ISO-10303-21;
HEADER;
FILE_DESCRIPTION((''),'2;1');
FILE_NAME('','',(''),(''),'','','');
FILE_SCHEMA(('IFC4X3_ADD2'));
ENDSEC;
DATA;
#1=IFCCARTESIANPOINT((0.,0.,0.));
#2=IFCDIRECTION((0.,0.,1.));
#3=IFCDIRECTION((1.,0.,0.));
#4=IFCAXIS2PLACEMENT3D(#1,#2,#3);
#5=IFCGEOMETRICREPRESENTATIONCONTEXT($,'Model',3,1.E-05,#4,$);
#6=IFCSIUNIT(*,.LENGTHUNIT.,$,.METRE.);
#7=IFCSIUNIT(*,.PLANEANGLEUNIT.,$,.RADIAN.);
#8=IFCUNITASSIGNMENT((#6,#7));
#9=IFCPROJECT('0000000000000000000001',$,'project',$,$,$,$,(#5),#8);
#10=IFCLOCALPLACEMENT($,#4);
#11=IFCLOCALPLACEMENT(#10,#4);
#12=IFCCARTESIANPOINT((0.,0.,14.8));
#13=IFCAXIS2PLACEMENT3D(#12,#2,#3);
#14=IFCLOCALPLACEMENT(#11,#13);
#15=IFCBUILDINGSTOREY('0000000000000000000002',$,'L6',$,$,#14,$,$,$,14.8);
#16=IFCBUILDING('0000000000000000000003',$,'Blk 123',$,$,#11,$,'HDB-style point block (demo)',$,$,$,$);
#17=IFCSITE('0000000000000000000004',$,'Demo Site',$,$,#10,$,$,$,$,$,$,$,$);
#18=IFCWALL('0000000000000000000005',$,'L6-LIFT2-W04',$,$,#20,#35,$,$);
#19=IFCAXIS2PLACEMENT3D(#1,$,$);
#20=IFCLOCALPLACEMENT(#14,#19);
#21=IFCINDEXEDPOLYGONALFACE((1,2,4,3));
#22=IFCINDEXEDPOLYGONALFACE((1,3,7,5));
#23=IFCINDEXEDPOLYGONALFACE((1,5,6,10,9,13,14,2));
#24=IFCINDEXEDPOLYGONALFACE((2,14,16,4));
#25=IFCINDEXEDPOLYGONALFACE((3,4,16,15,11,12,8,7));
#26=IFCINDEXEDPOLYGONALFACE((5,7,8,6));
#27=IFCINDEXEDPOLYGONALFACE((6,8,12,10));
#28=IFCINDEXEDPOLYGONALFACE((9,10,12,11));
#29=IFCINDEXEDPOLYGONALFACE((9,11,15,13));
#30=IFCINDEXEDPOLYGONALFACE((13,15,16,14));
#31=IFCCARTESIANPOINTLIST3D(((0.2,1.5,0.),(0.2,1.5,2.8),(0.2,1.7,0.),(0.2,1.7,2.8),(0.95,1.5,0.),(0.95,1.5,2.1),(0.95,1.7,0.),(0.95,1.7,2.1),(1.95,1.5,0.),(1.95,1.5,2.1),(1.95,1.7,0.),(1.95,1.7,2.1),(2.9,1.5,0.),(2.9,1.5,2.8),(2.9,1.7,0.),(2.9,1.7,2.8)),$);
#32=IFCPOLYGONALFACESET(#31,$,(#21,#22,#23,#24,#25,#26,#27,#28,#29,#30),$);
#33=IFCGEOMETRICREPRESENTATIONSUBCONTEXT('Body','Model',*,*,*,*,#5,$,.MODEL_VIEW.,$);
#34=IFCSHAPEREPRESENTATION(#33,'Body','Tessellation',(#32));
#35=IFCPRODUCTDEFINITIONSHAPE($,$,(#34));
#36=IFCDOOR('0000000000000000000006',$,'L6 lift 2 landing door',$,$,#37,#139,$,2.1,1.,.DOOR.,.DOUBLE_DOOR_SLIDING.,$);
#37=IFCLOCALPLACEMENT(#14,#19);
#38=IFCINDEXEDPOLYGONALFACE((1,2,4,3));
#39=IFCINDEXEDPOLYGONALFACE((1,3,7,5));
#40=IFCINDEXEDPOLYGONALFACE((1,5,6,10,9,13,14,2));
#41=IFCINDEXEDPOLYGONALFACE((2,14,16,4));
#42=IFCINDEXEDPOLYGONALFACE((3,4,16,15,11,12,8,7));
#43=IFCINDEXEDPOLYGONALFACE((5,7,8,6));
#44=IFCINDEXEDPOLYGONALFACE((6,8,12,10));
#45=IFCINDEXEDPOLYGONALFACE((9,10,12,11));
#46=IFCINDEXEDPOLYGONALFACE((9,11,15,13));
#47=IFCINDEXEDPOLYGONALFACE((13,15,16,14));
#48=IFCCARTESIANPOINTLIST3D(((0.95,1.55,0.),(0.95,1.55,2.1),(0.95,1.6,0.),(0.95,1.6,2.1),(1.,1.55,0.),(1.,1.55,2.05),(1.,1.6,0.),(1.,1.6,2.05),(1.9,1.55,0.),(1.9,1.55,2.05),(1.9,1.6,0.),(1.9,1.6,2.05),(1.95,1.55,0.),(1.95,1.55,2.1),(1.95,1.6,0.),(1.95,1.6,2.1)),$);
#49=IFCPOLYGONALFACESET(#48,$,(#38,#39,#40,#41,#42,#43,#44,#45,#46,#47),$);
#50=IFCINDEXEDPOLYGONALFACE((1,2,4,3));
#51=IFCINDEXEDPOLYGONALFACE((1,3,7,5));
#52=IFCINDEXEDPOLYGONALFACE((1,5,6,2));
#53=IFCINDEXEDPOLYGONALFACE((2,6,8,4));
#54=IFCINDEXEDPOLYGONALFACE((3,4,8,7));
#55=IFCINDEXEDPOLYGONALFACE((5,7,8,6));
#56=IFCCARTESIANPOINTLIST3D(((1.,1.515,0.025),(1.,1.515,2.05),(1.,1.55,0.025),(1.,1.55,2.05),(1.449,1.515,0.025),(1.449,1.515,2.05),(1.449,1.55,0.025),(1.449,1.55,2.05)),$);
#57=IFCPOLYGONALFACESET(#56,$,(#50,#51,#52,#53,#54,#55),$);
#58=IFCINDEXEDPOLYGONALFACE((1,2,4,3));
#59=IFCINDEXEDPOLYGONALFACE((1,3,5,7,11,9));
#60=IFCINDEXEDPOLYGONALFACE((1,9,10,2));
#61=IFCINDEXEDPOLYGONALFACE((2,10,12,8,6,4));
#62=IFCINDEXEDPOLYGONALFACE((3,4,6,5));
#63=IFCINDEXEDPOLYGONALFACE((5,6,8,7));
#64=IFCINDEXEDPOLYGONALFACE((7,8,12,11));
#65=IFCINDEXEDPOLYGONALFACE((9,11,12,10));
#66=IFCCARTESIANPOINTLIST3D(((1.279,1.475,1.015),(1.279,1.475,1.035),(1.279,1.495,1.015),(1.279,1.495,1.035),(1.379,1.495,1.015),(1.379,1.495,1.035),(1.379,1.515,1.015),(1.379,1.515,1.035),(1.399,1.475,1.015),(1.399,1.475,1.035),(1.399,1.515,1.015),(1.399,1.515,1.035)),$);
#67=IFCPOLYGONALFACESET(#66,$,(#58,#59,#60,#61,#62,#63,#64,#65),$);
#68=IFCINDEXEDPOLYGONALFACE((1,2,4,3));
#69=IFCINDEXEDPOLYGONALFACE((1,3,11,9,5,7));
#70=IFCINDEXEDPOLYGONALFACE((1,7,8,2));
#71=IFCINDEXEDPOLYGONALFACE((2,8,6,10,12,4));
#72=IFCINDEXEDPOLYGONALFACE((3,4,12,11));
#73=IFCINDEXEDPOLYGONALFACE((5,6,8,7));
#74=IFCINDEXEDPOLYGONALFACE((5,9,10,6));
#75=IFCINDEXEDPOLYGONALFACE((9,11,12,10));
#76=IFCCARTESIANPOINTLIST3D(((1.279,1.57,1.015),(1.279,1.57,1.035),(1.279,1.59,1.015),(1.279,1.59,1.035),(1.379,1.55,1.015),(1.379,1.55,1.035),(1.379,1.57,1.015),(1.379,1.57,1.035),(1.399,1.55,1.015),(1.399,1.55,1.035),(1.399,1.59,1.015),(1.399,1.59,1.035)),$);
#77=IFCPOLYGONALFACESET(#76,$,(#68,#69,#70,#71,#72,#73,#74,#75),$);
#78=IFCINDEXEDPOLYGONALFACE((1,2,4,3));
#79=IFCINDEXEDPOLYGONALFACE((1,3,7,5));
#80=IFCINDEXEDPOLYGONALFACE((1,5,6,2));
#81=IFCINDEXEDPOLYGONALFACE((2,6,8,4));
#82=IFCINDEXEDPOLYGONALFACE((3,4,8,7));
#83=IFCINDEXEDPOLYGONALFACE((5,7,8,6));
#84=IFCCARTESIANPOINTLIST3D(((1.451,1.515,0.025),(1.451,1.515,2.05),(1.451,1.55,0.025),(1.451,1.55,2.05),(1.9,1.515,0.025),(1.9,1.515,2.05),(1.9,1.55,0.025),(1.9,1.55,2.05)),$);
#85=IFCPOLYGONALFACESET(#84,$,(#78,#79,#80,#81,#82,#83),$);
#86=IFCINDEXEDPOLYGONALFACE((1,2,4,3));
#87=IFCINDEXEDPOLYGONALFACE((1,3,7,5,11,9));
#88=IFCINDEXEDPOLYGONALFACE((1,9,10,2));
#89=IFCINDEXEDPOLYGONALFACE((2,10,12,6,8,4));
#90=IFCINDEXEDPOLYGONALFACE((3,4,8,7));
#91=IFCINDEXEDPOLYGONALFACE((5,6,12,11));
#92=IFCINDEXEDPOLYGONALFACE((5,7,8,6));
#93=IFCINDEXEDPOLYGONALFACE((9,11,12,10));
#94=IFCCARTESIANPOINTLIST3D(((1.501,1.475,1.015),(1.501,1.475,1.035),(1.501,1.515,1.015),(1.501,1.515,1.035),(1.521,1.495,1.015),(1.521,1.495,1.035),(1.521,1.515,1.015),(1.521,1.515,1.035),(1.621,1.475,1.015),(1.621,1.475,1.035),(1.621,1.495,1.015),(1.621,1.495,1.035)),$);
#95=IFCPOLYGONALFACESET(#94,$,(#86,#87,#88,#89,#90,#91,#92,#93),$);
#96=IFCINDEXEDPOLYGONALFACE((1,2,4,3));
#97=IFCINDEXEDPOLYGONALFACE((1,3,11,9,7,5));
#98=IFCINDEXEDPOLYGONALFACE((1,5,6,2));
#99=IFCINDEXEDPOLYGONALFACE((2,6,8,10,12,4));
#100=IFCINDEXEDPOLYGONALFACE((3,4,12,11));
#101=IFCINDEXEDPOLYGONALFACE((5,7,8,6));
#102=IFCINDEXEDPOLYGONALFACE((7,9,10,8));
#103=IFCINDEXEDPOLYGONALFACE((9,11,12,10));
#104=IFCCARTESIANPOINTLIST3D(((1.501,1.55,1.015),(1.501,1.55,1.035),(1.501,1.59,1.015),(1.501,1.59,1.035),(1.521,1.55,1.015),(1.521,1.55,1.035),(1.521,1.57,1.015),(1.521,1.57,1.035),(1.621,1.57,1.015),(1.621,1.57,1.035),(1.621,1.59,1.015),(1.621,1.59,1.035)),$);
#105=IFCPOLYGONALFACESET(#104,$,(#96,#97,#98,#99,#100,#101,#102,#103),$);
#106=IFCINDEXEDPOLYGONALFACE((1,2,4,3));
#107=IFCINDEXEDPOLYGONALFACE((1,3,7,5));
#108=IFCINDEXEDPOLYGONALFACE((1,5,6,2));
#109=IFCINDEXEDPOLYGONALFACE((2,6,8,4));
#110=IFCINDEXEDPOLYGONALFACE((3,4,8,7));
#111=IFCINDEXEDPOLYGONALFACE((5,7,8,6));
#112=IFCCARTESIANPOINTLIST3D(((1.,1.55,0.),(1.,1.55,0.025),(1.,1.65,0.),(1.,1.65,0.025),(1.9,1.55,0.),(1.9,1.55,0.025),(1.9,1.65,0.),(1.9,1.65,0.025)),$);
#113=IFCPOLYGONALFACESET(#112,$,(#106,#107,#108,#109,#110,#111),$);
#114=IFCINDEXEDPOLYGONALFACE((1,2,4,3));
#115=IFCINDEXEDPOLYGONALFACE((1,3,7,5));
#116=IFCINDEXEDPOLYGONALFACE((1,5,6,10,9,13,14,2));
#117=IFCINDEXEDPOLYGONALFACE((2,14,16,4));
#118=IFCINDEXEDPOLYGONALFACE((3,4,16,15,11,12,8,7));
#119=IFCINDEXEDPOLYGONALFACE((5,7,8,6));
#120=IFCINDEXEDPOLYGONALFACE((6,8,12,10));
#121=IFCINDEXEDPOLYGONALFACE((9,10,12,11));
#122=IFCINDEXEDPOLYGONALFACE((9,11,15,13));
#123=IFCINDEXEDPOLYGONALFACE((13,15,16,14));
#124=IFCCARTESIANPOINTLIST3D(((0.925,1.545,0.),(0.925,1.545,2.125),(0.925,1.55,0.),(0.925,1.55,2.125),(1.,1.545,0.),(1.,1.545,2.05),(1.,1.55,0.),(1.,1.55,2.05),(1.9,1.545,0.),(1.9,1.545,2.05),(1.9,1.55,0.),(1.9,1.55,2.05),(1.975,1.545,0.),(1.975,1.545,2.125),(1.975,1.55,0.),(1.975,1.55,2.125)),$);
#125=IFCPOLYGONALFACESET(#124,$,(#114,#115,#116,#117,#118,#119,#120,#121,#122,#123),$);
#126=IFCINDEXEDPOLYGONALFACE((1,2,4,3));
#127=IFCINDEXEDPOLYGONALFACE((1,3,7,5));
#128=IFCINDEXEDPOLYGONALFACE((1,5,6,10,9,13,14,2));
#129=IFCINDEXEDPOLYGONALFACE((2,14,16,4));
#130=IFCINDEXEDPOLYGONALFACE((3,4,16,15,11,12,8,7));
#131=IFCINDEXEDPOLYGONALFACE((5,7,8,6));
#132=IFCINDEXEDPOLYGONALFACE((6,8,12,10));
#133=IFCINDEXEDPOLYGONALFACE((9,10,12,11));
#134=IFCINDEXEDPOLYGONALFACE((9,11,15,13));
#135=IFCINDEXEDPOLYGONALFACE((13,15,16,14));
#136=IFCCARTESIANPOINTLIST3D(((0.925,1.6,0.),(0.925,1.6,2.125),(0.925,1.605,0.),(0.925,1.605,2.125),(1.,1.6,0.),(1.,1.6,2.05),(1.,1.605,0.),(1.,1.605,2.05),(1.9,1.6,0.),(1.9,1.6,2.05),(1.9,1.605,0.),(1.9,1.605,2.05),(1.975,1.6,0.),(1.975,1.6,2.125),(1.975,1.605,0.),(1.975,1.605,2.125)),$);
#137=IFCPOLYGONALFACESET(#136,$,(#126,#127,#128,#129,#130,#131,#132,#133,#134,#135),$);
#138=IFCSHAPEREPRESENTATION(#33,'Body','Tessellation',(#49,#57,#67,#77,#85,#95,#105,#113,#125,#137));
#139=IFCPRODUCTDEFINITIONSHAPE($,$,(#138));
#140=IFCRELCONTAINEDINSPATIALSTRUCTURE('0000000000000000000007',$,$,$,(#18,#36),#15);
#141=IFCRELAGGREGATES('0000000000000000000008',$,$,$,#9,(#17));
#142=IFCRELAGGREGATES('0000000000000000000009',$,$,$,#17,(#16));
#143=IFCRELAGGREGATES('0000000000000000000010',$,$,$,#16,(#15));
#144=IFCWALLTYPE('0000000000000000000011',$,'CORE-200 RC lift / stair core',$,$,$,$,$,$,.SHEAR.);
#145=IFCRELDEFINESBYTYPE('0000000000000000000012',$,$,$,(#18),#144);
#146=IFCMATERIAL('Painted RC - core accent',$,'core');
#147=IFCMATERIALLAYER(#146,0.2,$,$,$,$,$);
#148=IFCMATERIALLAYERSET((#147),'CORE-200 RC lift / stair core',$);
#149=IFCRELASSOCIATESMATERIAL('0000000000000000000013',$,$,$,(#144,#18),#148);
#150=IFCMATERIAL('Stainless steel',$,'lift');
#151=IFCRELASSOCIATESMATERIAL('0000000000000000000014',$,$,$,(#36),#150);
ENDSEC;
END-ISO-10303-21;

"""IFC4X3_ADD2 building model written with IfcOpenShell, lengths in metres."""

from ifc_helpers import new_model, si_unit, frame, origin_with_axes, place, context, subcontext, project, spatial, line, indexed_curve, outline, extrude, material, layer, layer_set, layer_usage, type_object, element, fill, save


model = new_model("IFC4X3_ADD2")

# Units and contexts
model_context = context("Model", 3, precision=1e-05, world=origin_with_axes())
body_context = subcontext(model_context, "Body", "Model", "MODEL_VIEW")
ifc_project = project(units=[si_unit("LENGTHUNIT", "METRE"), si_unit("PLANEANGLEUNIT", "RADIAN")], contexts=[model_context])

# Site, building, storey
site_placement = place(None, origin_with_axes())
site = spatial("IfcSite", under=ifc_project, at=site_placement, Name="Demo Site")
building_placement = place(site_placement, origin_with_axes())
building = spatial("IfcBuilding", under=site, at=building_placement, Name="Blk 123", LongName="HDB-style point block (demo)")
storey_placement = place(building_placement, frame((0.0, 0.0, 14.8), z_axis=(0.0, 0.0, 1.0), x_axis=(1.0, 0.0, 0.0)))
storey = spatial("IfcBuildingStorey", under=building, at=storey_placement, Name="L6", Elevation=14.8)

# Shared definitions
ifc_material_1 = material(Name="Painted RC - core accent", Category="core")
ifc_layer_1 = layer(ifc_material_1, 0.2)
ifc_layer_set_1 = layer_set([ifc_layer_1], Name="CORE-200 RC lift / stair core")
ifc_layer_usage_1 = layer_usage(ifc_layer_set_1, "AXIS2", "POSITIVE", 0.0)
wall_type_1 = type_object("IfcWallType", Name="CORE-200 RC lift / stair core", PredefinedType="SHEAR", material=ifc_layer_set_1)

# Wall, opening, door
wall_1_placement = place(storey_placement, frame((0.2, 1.5, 0.0), z_axis=(0.0, 0.0, 1.0), x_axis=(1.0, 0.0, 0.0)))
wall_1 = element("IfcWall", 1, at=wall_1_placement, inside=storey, type_object=wall_type_1, material=ifc_layer_usage_1, Name="L6-LIFT2-W04", context=body_context, shape_type="SweptSolid", body=[
    extrude(outline(indexed_curve([(0.0, 0.0), (0.0, 0.2), (2.7, 0.2), (2.7, 0.0), (0.0, 0.0)], self_intersect=False)), origin_with_axes(), (0.0, 0.0, 1.0), 2.8),
])
opening_1_placement = place(wall_1_placement, frame((0.75, -0.1, 0.0), z_axis=(0.0, 0.0, 1.0), x_axis=(1.0, 0.0, 0.0)))
opening_1 = element("IfcOpeningElement", 2, at=opening_1_placement, cuts=wall_1, context=body_context, shape_type="SweptSolid", body=[
    extrude(outline(indexed_curve([(0.0, 0.0), (0.0, 0.4), (1.0, 0.4), (1.0, 0.0), (0.0, 0.0)], self_intersect=False)), origin_with_axes(), (0.0, 0.0, 1.0), 2.1),
])
ifc_material_2 = material(Name="Stainless steel", Category="lift")
door_1_placement = place(opening_1_placement, frame((0.0, 0.15, 0.0), z_axis=(0.0, 0.0, 1.0), x_axis=(1.0, 0.0, 0.0)))
door_1 = element("IfcDoor", 3, at=door_1_placement, inside=storey, material=ifc_material_2, Name="L6 lift 2 landing door", OperationType="DOUBLE_DOOR_SLIDING", OverallHeight=2.1, OverallWidth=1.0, PredefinedType="DOOR", context=body_context, shape_type="SweptSolid", body=[
    extrude(outline(indexed_curve([(0.0, 0.0), (0.0, 2.1), (1.0, 2.1), (1.0, 0.0), (0.95, 0.0), (0.95, 2.05), (0.05, 2.05), (0.05, 0.0)], segments=[line(1, 2, 3, 4, 5, 6, 7, 8, 1)])), frame((0.0, 0.0, 0.0), z_axis=(0.0, -1.0, 0.0), x_axis=(1.0, 0.0, 0.0)), (0.0, 0.0, -1.0), 0.05),
    extrude(outline(indexed_curve([(0.0, 0.0), (0.449, 0.0), (0.449, 0.035), (0.0, 0.035)], segments=[line(1, 2, 3, 4, 1)])), frame((0.05, -0.035, 0.025), z_axis=(0.0, 0.0, 1.0), x_axis=(1.0, 0.0, 0.0)), (0.0, 0.0, 1.0), 2.025),
    extrude(outline(indexed_curve([(0.0, 0.0), (0.0, -0.04), (-0.12, -0.04), (-0.12, -0.02), (-0.02, -0.02), (-0.02, 0.0)], segments=[line(1, 2, 3, 4, 5, 6, 1)])), frame((0.449, -0.035, 1.015), z_axis=(0.0, 0.0, 1.0), x_axis=(1.0, 0.0, 0.0)), (0.0, 0.0, 1.0), 0.02),
    extrude(outline(indexed_curve([(0.0, 0.0), (0.0, 0.04), (-0.12, 0.04), (-0.12, 0.02), (-0.02, 0.02), (-0.02, 0.0)], segments=[line(1, 2, 3, 4, 5, 6, 1)])), frame((0.449, 0.0, 1.015), z_axis=(0.0, 0.0, 1.0), x_axis=(1.0, 0.0, 0.0)), (0.0, 0.0, 1.0), 0.02),
    extrude(outline(indexed_curve([(0.0, 0.0), (-0.449, 0.0), (-0.449, 0.035), (0.0, 0.035)], segments=[line(1, 2, 3, 4, 1)])), frame((0.95, -0.035, 0.025), z_axis=(0.0, 0.0, 1.0), x_axis=(1.0, 0.0, 0.0)), (0.0, 0.0, 1.0), 2.025),
    extrude(outline(indexed_curve([(0.0, 0.0), (0.0, -0.04), (0.12, -0.04), (0.12, -0.02), (0.02, -0.02), (0.02, 0.0)], segments=[line(1, 2, 3, 4, 5, 6, 1)])), frame((0.551, -0.035, 1.015), z_axis=(0.0, 0.0, 1.0), x_axis=(1.0, 0.0, 0.0)), (0.0, 0.0, 1.0), 0.02),
    extrude(outline(indexed_curve([(0.0, 0.0), (0.0, 0.04), (0.12, 0.04), (0.12, 0.02), (0.02, 0.02), (0.02, 0.0)], segments=[line(1, 2, 3, 4, 5, 6, 1)])), frame((0.551, 0.0, 1.015), z_axis=(0.0, 0.0, 1.0), x_axis=(1.0, 0.0, 0.0)), (0.0, 0.0, 1.0), 0.02),
    extrude(outline(indexed_curve([(0.0, 0.0), (0.9, 0.0), (0.9, 0.1), (0.0, 0.1)], segments=[line(1, 2, 3, 4, 1)])), frame((0.05, 0.0, 0.0), z_axis=(0.0, 0.0, 1.0), x_axis=(1.0, 0.0, 0.0)), (0.0, 0.0, 1.0), 0.025),
    extrude(outline(indexed_curve([(0.0, 0.0), (0.0, 2.125), (1.05, 2.125), (1.05, 0.0), (0.975, 0.0), (0.975, 2.05), (0.075, 2.05), (0.075, 0.0)], segments=[line(1, 2, 3, 4, 5, 6, 7, 8, 1)])), frame((-0.025, -0.005, 0.0), z_axis=(0.0, -1.0, 0.0), x_axis=(1.0, 0.0, 0.0)), (0.0, 0.0, -1.0), 0.005),
    extrude(outline(indexed_curve([(0.0, 0.0), (0.0, 2.125), (1.05, 2.125), (1.05, 0.0), (0.975, 0.0), (0.975, 2.05), (0.075, 2.05), (0.075, 0.0)], segments=[line(1, 2, 3, 4, 5, 6, 7, 8, 1)])), frame((-0.025, 0.05, 0.0), z_axis=(0.0, -1.0, 0.0), x_axis=(1.0, 0.0, 0.0)), (0.0, 0.0, -1.0), 0.005),
])
fill(opening_1, door_1)

save(model, "model.ifc")
